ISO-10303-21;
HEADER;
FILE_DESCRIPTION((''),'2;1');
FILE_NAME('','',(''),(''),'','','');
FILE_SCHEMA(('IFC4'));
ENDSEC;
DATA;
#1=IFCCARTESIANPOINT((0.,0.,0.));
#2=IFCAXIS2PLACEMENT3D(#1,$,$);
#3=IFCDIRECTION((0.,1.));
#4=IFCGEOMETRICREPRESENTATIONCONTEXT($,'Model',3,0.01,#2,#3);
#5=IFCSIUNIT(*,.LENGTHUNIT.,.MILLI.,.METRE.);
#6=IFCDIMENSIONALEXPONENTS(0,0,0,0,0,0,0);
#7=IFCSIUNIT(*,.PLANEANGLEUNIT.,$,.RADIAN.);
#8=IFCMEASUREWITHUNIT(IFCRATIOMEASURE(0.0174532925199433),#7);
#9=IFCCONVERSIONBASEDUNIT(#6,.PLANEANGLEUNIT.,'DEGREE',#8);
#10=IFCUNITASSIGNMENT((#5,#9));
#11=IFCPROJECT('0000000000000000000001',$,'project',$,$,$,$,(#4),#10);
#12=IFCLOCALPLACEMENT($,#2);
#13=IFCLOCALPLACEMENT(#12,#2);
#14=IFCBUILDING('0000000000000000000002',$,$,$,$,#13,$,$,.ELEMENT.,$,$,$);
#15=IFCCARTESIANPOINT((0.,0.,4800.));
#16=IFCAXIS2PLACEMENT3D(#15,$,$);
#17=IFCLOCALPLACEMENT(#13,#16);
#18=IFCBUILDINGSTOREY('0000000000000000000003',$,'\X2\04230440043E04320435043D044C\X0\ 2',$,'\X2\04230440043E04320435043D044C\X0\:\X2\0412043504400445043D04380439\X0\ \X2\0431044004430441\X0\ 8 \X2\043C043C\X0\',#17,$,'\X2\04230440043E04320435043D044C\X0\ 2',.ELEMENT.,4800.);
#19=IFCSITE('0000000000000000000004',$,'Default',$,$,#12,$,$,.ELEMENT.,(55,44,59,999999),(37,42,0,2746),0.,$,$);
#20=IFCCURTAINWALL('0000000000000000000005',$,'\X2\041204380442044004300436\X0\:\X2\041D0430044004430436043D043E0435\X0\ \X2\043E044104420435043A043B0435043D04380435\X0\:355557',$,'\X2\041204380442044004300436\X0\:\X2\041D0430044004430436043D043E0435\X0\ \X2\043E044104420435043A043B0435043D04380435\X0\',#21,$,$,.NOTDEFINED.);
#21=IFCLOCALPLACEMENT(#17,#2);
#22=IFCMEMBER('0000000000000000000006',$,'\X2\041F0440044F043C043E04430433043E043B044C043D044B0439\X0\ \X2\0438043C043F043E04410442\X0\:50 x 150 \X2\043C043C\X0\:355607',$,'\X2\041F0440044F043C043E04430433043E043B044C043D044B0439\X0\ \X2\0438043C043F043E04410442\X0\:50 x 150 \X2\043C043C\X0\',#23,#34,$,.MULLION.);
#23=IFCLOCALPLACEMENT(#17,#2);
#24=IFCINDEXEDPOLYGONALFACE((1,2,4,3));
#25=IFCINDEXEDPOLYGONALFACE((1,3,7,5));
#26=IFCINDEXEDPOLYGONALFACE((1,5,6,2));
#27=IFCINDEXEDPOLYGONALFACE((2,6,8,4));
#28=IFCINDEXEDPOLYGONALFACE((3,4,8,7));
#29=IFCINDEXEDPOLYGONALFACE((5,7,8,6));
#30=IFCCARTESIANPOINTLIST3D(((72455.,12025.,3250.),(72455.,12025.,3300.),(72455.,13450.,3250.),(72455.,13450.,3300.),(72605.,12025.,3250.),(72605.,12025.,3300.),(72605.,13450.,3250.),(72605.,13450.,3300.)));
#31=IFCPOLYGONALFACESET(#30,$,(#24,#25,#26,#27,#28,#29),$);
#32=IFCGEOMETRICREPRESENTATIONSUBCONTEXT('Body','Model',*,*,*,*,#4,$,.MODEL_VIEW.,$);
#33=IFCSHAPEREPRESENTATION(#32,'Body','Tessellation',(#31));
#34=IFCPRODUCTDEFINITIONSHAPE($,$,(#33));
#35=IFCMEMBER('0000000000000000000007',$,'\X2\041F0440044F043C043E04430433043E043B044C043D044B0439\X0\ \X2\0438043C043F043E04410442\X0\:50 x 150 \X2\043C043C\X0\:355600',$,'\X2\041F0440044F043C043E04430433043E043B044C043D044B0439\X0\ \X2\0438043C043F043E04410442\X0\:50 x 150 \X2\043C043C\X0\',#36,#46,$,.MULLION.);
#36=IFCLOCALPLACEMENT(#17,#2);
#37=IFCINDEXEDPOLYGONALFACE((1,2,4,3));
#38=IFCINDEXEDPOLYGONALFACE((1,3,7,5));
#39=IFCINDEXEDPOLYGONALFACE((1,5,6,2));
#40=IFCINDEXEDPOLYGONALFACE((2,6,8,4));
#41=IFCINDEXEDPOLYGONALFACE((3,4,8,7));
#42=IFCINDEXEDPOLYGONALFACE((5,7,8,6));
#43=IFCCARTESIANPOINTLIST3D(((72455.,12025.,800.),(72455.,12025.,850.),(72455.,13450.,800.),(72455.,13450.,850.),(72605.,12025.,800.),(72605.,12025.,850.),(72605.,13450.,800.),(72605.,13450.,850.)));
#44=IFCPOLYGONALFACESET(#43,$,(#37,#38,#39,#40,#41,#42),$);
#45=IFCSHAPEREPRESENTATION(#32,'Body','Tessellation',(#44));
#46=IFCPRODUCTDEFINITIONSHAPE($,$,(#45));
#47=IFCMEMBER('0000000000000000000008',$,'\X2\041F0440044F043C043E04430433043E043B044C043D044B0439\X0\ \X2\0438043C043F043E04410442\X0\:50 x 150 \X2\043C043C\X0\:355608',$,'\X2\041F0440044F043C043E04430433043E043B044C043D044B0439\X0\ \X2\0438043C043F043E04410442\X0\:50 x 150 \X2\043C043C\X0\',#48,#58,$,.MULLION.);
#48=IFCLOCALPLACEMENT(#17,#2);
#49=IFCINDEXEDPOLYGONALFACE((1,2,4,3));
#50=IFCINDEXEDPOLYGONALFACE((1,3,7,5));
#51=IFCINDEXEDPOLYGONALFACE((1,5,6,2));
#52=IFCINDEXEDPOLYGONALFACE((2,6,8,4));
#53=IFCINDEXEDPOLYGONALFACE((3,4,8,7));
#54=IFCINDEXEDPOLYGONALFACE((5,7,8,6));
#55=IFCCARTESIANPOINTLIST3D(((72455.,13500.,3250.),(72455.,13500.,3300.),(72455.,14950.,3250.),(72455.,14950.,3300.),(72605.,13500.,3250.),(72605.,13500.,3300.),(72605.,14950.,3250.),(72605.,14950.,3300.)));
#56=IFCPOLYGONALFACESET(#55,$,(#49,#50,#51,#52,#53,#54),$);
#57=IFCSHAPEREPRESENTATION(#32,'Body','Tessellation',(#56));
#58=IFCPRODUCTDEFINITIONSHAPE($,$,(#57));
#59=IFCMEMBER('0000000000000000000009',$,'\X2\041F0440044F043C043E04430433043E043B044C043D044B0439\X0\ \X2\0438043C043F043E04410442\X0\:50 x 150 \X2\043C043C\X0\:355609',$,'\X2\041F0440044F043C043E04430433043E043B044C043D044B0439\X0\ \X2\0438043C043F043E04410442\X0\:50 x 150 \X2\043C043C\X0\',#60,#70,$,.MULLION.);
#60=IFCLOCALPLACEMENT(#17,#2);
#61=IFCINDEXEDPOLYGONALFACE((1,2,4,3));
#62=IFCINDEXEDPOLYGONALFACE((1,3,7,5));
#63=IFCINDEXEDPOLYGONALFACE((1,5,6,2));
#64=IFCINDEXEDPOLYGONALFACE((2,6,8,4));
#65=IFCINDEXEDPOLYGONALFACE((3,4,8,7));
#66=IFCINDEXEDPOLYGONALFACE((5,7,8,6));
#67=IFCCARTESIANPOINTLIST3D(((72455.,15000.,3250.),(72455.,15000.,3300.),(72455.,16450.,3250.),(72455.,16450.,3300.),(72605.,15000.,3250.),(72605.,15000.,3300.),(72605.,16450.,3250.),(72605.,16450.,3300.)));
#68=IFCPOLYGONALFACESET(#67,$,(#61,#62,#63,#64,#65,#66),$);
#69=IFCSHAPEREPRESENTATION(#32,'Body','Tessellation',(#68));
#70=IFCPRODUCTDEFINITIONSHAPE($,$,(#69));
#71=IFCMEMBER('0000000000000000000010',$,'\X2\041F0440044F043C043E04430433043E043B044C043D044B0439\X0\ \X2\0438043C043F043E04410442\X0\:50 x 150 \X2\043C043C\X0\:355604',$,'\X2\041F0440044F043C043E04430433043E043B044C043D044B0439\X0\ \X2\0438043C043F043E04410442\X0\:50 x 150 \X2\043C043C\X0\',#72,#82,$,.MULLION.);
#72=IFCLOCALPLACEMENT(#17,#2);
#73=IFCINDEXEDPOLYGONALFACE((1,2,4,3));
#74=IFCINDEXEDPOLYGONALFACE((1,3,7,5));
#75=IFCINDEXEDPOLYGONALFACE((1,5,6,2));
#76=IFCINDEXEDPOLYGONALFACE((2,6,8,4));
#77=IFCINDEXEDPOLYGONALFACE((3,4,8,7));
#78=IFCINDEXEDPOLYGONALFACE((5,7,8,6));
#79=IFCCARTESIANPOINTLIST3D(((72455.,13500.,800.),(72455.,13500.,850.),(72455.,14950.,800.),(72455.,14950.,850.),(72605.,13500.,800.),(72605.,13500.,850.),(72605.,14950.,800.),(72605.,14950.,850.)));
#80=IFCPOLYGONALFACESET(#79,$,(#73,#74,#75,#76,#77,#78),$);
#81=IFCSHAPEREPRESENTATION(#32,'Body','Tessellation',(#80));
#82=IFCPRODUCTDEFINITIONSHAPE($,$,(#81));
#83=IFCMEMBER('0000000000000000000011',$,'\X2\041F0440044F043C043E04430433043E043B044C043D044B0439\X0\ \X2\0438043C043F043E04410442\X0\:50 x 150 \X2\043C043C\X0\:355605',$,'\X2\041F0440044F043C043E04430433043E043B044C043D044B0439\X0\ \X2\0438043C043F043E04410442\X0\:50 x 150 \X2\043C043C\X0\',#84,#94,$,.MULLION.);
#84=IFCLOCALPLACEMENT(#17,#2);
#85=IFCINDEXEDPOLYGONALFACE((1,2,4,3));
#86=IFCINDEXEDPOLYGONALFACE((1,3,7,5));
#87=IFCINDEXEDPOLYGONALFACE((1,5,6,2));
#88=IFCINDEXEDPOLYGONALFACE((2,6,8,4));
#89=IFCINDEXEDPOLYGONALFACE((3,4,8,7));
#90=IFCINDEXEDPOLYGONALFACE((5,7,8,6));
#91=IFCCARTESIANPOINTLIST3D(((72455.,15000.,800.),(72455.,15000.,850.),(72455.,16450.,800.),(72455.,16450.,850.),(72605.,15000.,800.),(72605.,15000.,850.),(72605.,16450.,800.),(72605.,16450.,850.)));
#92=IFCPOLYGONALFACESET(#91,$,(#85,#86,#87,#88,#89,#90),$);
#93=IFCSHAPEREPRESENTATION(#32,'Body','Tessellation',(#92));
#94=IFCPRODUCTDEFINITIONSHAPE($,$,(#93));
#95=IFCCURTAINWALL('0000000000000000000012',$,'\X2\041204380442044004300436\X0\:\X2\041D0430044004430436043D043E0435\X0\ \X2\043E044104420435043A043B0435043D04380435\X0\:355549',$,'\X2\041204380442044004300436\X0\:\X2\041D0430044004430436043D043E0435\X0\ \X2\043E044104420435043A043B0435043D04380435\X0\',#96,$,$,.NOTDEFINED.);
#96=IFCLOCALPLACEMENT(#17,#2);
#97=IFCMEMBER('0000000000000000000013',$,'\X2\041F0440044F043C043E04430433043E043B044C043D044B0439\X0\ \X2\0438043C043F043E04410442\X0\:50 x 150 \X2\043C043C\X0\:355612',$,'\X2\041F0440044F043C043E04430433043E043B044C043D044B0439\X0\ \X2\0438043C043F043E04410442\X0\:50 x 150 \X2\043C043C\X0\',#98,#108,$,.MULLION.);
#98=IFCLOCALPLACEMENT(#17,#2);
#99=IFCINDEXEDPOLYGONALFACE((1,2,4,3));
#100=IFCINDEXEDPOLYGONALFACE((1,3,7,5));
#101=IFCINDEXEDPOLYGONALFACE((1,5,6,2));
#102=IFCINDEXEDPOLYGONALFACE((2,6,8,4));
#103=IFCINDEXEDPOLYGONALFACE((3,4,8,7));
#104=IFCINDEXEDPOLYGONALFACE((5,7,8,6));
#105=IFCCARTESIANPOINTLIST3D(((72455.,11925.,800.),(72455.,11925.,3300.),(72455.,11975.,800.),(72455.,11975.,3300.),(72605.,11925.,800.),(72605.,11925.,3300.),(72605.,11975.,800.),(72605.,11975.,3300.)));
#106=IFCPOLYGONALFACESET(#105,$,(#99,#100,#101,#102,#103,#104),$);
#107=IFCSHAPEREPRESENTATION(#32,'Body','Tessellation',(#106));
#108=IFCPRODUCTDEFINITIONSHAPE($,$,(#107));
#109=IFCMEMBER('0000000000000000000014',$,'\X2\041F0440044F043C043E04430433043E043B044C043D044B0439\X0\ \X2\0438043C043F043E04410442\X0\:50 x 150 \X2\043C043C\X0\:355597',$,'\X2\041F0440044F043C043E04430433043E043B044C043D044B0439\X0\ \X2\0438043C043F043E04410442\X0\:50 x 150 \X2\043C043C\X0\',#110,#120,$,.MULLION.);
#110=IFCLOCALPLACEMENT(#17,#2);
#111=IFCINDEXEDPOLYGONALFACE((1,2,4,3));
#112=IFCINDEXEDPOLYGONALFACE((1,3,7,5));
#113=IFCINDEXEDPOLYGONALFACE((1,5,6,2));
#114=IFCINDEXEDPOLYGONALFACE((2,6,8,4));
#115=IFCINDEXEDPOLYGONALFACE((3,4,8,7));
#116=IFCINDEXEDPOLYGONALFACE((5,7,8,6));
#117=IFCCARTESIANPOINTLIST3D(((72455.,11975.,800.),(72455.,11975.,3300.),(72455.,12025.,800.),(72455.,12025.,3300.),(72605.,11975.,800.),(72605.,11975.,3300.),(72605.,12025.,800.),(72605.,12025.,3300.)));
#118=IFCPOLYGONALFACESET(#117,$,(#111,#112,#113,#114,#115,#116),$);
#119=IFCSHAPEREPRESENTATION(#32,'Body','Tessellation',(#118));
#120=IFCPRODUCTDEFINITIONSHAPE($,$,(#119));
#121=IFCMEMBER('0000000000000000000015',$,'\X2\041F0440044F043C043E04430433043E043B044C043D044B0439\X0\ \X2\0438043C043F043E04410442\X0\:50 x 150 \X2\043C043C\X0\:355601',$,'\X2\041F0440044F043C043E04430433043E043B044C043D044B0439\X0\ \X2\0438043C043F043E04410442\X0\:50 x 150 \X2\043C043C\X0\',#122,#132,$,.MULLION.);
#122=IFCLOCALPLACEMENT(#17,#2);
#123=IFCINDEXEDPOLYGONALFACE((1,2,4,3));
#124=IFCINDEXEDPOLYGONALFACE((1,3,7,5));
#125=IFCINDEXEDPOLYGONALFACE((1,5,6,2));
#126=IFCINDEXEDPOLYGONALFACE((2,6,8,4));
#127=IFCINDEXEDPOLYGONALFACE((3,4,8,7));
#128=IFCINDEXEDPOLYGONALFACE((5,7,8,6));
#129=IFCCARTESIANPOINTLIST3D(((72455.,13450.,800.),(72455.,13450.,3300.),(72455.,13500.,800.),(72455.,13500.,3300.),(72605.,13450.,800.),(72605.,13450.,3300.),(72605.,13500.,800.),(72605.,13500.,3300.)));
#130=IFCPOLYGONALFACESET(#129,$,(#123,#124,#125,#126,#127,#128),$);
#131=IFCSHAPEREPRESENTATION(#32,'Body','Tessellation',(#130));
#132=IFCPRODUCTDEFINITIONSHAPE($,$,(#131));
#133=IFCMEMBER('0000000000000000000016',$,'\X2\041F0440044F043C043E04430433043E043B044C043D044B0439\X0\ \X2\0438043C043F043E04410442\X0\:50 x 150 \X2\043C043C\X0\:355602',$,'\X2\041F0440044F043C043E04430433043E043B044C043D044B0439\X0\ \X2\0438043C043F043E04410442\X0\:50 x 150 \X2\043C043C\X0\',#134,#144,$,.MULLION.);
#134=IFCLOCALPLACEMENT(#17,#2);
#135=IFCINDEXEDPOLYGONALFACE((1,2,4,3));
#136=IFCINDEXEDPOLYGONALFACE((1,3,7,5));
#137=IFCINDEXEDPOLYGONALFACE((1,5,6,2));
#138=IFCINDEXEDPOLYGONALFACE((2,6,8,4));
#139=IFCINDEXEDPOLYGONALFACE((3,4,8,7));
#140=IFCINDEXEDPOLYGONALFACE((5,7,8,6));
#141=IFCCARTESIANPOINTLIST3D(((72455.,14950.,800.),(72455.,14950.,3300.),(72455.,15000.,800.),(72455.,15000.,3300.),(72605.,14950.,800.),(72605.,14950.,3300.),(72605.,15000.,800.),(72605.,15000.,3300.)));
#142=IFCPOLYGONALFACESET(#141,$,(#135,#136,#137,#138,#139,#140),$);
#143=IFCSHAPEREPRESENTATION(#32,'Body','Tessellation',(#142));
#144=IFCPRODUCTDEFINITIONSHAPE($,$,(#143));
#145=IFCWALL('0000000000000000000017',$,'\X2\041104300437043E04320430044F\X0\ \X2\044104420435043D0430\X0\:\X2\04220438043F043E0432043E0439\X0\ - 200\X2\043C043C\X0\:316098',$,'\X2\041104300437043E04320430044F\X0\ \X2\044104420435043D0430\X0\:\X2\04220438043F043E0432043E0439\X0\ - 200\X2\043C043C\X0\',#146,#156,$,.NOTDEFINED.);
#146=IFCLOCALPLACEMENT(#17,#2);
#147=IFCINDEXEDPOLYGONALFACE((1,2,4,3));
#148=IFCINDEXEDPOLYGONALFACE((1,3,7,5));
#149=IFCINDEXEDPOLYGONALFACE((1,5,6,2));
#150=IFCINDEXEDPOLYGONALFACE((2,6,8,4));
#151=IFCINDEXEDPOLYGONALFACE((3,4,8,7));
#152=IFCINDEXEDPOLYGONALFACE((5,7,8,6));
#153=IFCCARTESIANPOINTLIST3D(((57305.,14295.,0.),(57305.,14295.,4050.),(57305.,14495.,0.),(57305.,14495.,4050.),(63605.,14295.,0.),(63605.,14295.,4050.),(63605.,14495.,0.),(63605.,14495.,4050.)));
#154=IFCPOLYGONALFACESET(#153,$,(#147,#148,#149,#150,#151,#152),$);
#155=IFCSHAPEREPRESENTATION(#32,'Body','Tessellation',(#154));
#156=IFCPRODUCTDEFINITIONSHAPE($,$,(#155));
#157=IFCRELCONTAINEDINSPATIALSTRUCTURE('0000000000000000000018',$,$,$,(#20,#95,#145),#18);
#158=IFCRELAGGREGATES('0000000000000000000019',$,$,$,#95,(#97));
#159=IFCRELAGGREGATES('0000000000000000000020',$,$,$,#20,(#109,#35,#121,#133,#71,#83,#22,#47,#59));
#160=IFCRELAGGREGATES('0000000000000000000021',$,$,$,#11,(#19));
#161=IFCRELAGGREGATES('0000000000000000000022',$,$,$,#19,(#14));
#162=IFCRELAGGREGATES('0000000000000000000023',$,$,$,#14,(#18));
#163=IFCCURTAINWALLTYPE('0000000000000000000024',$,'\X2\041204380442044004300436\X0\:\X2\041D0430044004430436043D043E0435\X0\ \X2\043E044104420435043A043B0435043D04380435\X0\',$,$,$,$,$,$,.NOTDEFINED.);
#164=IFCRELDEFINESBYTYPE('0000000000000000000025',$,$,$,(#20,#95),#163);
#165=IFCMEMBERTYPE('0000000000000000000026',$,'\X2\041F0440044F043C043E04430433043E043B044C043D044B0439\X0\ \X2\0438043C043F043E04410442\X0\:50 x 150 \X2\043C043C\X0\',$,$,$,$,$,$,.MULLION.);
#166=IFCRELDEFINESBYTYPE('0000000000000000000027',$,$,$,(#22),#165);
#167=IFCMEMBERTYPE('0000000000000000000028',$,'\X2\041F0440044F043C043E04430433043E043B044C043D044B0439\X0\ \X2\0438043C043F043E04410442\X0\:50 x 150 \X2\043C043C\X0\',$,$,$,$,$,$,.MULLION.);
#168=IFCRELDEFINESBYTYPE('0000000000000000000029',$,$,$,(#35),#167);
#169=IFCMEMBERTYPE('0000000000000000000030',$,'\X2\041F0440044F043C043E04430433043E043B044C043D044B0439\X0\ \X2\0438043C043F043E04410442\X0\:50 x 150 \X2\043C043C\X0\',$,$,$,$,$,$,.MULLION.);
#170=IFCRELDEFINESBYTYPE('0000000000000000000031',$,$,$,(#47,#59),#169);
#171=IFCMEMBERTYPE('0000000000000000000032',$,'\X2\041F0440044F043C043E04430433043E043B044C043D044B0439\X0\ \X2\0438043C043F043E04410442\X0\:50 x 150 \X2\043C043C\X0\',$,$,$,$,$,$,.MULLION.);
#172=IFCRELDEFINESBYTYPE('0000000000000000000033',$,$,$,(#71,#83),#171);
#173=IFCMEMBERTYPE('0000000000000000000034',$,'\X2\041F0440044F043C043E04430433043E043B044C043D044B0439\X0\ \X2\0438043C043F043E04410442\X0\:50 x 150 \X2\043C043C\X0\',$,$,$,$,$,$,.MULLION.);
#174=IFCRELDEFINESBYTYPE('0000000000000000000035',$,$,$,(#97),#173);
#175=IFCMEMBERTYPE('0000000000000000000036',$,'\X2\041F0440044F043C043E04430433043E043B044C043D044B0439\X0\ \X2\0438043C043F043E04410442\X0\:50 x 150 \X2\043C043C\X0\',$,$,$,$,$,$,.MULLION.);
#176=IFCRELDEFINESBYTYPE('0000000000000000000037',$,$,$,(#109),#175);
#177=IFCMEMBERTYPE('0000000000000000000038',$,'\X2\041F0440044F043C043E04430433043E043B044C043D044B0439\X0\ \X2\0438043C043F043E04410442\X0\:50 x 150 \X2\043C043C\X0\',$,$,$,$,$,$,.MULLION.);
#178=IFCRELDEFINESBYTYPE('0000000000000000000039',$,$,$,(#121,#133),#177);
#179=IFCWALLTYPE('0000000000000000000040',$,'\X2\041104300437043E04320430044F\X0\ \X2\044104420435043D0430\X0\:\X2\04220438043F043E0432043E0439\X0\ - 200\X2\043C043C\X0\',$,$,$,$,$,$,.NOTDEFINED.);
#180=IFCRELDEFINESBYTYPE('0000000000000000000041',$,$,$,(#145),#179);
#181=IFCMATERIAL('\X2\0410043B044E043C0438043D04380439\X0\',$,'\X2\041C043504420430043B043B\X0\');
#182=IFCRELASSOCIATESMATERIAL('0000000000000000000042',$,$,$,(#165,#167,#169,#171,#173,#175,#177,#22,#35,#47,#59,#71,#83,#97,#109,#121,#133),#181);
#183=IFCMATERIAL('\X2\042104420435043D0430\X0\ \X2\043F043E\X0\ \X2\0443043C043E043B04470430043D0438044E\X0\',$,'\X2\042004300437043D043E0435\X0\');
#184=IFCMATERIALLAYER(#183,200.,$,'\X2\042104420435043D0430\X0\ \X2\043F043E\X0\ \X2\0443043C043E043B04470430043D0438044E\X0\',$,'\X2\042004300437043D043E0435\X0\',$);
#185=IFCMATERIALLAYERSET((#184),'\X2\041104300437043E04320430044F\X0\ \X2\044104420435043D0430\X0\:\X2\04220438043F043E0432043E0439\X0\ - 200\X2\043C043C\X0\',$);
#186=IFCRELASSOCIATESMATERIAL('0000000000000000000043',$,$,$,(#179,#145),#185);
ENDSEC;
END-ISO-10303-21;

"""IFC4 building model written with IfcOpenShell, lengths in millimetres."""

from ifc_helpers import new_model, entity, si_unit, converted_unit, direction, frame, frame_2d, origin, origin_2d_with_axis, place, context, subcontext, project, spatial, rectangle, extrude, source, transform, mapped, material, layer, layer_set, layer_usage, material_profile, profile_set, profile_usage, type_object, type_shapes, element, aggregate, save


model = new_model("IFC4")

# Units and contexts
model_context = context("Model", 3, precision=0.01, world=origin(), true_north=direction((0.0, 1.0)))
body_context = subcontext(model_context, "Body", "Model", "MODEL_VIEW")
ifc_project = project(units=[si_unit("LENGTHUNIT", "METRE", prefix="MILLI"), converted_unit("PLANEANGLEUNIT", "DEGREE", entity("IfcRatioMeasure", 0.0174532925199433), si_unit("PLANEANGLEUNIT", "RADIAN"), dimensions=[0, 0, 0, 0, 0, 0, 0])], contexts=[model_context])

# Site, building, storey
site_placement = place(None, origin())
site = spatial("IfcSite", under=ifc_project, at=site_placement, Name="Default", CompositionType="ELEMENT", RefLatitude=(55, 44, 59, 999999), RefLongitude=(37, 42, 0, 2746), RefElevation=0.0)
building_placement = place(site_placement, origin())
building = spatial("IfcBuilding", under=site, at=building_placement, CompositionType="ELEMENT")
storey_placement = place(building_placement, frame((0.0, 0.0, 4800.0)))
storey = spatial("IfcBuildingStorey", under=building, at=storey_placement, Name="Уровень 2", ObjectType="Уровень:Верхний брус 8 мм", LongName="Уровень 2", CompositionType="ELEMENT", Elevation=4800.0)

# Curtain wall, members
curtain_wall_type = type_object("IfcCurtainWallType", Name="Витраж:Наружное остекление", PredefinedType="NOTDEFINED")
curtain_wall_1_placement = place(storey_placement, frame((0.0, 0.0, -4800.0)))
curtain_wall_1 = element("IfcCurtainWall", 1, at=curtain_wall_1_placement, inside=storey, type_object=curtain_wall_type, Name="Витраж:Наружное остекление:355557", ObjectType="Витраж:Наружное остекление", PredefinedType="NOTDEFINED")
ifc_material_1 = material(Name="Алюминий", Category="Металл")
ifc_material_profile = material_profile(ifc_material_1, rectangle(XDim=150.0, YDim=50.0, at=origin_2d_with_axis()), Name="50 x 150 мм")
ifc_profile_set = profile_set([ifc_material_profile], Name="50 x 150 мм")
ifc_profile_usage_1 = profile_usage(ifc_profile_set)
member_type_1 = type_object("IfcMemberType", Name="Прямоугольный импост:50 x 150 мм", PredefinedType="MULLION", material=ifc_profile_set)
shared_shape_1 = source(origin(), body_context, "Body", "SweptSolid", [
    extrude(rectangle(XDim=150.0, YDim=50.0, at=origin_2d_with_axis()), frame((-25.0, 0.0, -1425.0), z_axis=(0.0, 0.0, 1.0), x_axis=(0.0, -1.0, 0.0)), (0.0, 0.0, 1.0), 1425.0),
])
type_shapes(member_type_1, [shared_shape_1])
member_1_placement = place(storey_placement, frame((72530.0, 13450.0, 3300.0), z_axis=(0.0, 1.0, 0.0), x_axis=(0.0, 0.0, 1.0)))
member_1 = element("IfcMember", 2, at=member_1_placement, type_object=member_type_1, material=ifc_profile_usage_1, Name="Прямоугольный импост:50 x 150 мм:355607", ObjectType="Прямоугольный импост:50 x 150 мм", PredefinedType="MULLION", context=body_context, shape_type="MappedRepresentation", body=[
    mapped(shared_shape_1, transform((0.0, 0.0, 0.0), scale=1.0)),
])
ifc_profile_usage_2 = profile_usage(ifc_profile_set)
member_type_2 = type_object("IfcMemberType", Name="Прямоугольный импост:50 x 150 мм", PredefinedType="MULLION", material=ifc_profile_set)
shared_shape_2 = source(origin(), body_context, "Body", "SweptSolid", [
    extrude(rectangle(XDim=150.0, YDim=50.0, at=origin_2d_with_axis()), frame((-25.0, 0.0, -1425.0), z_axis=(0.0, 0.0, 1.0), x_axis=(0.0, -1.0, 0.0)), (0.0, 0.0, 1.0), 1425.0),
])
type_shapes(member_type_2, [shared_shape_2])
member_2_placement = place(storey_placement, frame((72530.0, 12025.0, 800.0), z_axis=(0.0, -1.0, 0.0), x_axis=(0.0, 0.0, -1.0)))
member_2 = element("IfcMember", 3, at=member_2_placement, type_object=member_type_2, material=ifc_profile_usage_2, Name="Прямоугольный импост:50 x 150 мм:355600", ObjectType="Прямоугольный импост:50 x 150 мм", PredefinedType="MULLION", context=body_context, shape_type="MappedRepresentation", body=[
    mapped(shared_shape_2, transform((0.0, 0.0, 0.0), scale=1.0)),
])
ifc_profile_usage_3 = profile_usage(ifc_profile_set)
member_type_3 = type_object("IfcMemberType", Name="Прямоугольный импост:50 x 150 мм", PredefinedType="MULLION", material=ifc_profile_set)
shared_shape_3 = source(origin(), body_context, "Body", "SweptSolid", [
    extrude(rectangle(XDim=150.0, YDim=50.0, at=origin_2d_with_axis()), frame((-25.0, 0.0, -1450.0), z_axis=(0.0, 0.0, 1.0), x_axis=(0.0, -1.0, 0.0)), (0.0, 0.0, 1.0), 1450.0),
])
type_shapes(member_type_3, [shared_shape_3])
member_3_placement = place(storey_placement, frame((72530.0, 14950.0, 3300.0), z_axis=(0.0, 1.0, 0.0), x_axis=(0.0, 0.0, 1.0)))
member_3 = element("IfcMember", 4, at=member_3_placement, type_object=member_type_3, material=ifc_profile_usage_3, Name="Прямоугольный импост:50 x 150 мм:355608", ObjectType="Прямоугольный импост:50 x 150 мм", PredefinedType="MULLION", context=body_context, shape_type="MappedRepresentation", body=[
    mapped(shared_shape_3, transform((0.0, 0.0, 0.0), scale=1.0)),
])
ifc_profile_usage_4 = profile_usage(ifc_profile_set)
member_4_placement = place(storey_placement, frame((72530.0, 16450.0, 3300.0), z_axis=(0.0, 1.0, 0.0), x_axis=(0.0, 0.0, 1.0)))
member_4 = element("IfcMember", 5, at=member_4_placement, type_object=member_type_3, material=ifc_profile_usage_4, Name="Прямоугольный импост:50 x 150 мм:355609", ObjectType="Прямоугольный импост:50 x 150 мм", PredefinedType="MULLION", context=body_context, shape_type="MappedRepresentation", body=[
    mapped(shared_shape_3, transform((0.0, 0.0, 0.0), scale=1.0)),
])
ifc_profile_usage_5 = profile_usage(ifc_profile_set)
member_type_4 = type_object("IfcMemberType", Name="Прямоугольный импост:50 x 150 мм", PredefinedType="MULLION", material=ifc_profile_set)
shared_shape_4 = source(origin(), body_context, "Body", "SweptSolid", [
    extrude(rectangle(XDim=150.0, YDim=50.0, at=origin_2d_with_axis()), frame((-25.0, 0.0, -1450.0), z_axis=(0.0, 0.0, 1.0), x_axis=(0.0, -1.0, 0.0)), (0.0, 0.0, 1.0), 1450.0),
])
type_shapes(member_type_4, [shared_shape_4])
member_5_placement = place(storey_placement, frame((72530.0, 13500.0, 800.0), z_axis=(0.0, -1.0, 0.0), x_axis=(0.0, 0.0, -1.0)))
member_5 = element("IfcMember", 6, at=member_5_placement, type_object=member_type_4, material=ifc_profile_usage_5, Name="Прямоугольный импост:50 x 150 мм:355604", ObjectType="Прямоугольный импост:50 x 150 мм", PredefinedType="MULLION", context=body_context, shape_type="MappedRepresentation", body=[
    mapped(shared_shape_4, transform((0.0, 0.0, 0.0), scale=1.0)),
])
ifc_profile_usage_6 = profile_usage(ifc_profile_set)
member_6_placement = place(storey_placement, frame((72530.0, 15000.0, 800.0), z_axis=(0.0, -1.0, 0.0), x_axis=(0.0, 0.0, -1.0)))
member_6 = element("IfcMember", 7, at=member_6_placement, type_object=member_type_4, material=ifc_profile_usage_6, Name="Прямоугольный импост:50 x 150 мм:355605", ObjectType="Прямоугольный импост:50 x 150 мм", PredefinedType="MULLION", context=body_context, shape_type="MappedRepresentation", body=[
    mapped(shared_shape_4, transform((0.0, 0.0, 0.0), scale=1.0)),
])

# Curtain wall, member
curtain_wall_2_placement = place(storey_placement, frame((0.0, 0.0, -4800.0)))
curtain_wall_2 = element("IfcCurtainWall", 8, at=curtain_wall_2_placement, inside=storey, type_object=curtain_wall_type, Name="Витраж:Наружное остекление:355549", ObjectType="Витраж:Наружное остекление", PredefinedType="NOTDEFINED")
ifc_profile_usage_7 = profile_usage(ifc_profile_set)
member_type_5 = type_object("IfcMemberType", Name="Прямоугольный импост:50 x 150 мм", PredefinedType="MULLION", material=ifc_profile_set)
shared_shape_5 = source(origin(), body_context, "Body", "SweptSolid", [
    extrude(rectangle(XDim=150.0, YDim=50.0, at=origin_2d_with_axis()), frame((-25.0, 0.0, -2500.0), z_axis=(0.0, 0.0, 1.0), x_axis=(0.0, -1.0, 0.0)), (0.0, 0.0, 1.0), 2500.0),
])
type_shapes(member_type_5, [shared_shape_5])
member_7_placement = place(storey_placement, frame((72530.0, 11975.0, 800.0), z_axis=(0.0, 0.0, -1.0), x_axis=(0.0, 1.0, 0.0)))
member_7 = element("IfcMember", 9, at=member_7_placement, type_object=member_type_5, material=ifc_profile_usage_7, Name="Прямоугольный импост:50 x 150 мм:355612", ObjectType="Прямоугольный импост:50 x 150 мм", PredefinedType="MULLION", context=body_context, shape_type="MappedRepresentation", body=[
    mapped(shared_shape_5, transform((0.0, 0.0, 0.0), scale=1.0)),
])
aggregate(curtain_wall_2, [member_7])

# Members
ifc_profile_usage_8 = profile_usage(ifc_profile_set)
member_type_6 = type_object("IfcMemberType", Name="Прямоугольный импост:50 x 150 мм", PredefinedType="MULLION", material=ifc_profile_set)
shared_shape_6 = source(origin(), body_context, "Body", "SweptSolid", [
    extrude(rectangle(XDim=150.0, YDim=50.0, at=origin_2d_with_axis()), frame((-25.0, 0.0, -2500.0), z_axis=(0.0, 0.0, 1.0), x_axis=(0.0, -1.0, 0.0)), (0.0, 0.0, 1.0), 2500.0),
])
type_shapes(member_type_6, [shared_shape_6])
member_8_placement = place(storey_placement, frame((72530.0, 11975.0, 3300.0), z_axis=(0.0, 0.0, 1.0), x_axis=(0.0, -1.0, 0.0)))
member_8 = element("IfcMember", 10, at=member_8_placement, type_object=member_type_6, material=ifc_profile_usage_8, Name="Прямоугольный импост:50 x 150 мм:355597", ObjectType="Прямоугольный импост:50 x 150 мм", PredefinedType="MULLION", context=body_context, shape_type="MappedRepresentation", body=[
    mapped(shared_shape_6, transform((0.0, 0.0, 0.0), scale=1.0)),
])
ifc_profile_usage_9 = profile_usage(ifc_profile_set)
member_type_7 = type_object("IfcMemberType", Name="Прямоугольный импост:50 x 150 мм", PredefinedType="MULLION", material=ifc_profile_set)
shared_shape_7 = source(origin(), body_context, "Body", "SweptSolid", [
    extrude(rectangle(XDim=150.0, YDim=50.0, at=origin_2d_with_axis()), frame((0.0, 0.0, -2500.0), z_axis=(0.0, 0.0, 1.0), x_axis=(0.0, -1.0, 0.0)), (0.0, 0.0, 1.0), 2500.0),
])
type_shapes(member_type_7, [shared_shape_7])
member_9_placement = place(storey_placement, frame((72530.0, 13475.0, 800.0), z_axis=(0.0, 0.0, -1.0), x_axis=(0.0, 1.0, 0.0)))
member_9 = element("IfcMember", 11, at=member_9_placement, type_object=member_type_7, material=ifc_profile_usage_9, Name="Прямоугольный импост:50 x 150 мм:355601", ObjectType="Прямоугольный импост:50 x 150 мм", PredefinedType="MULLION", context=body_context, shape_type="MappedRepresentation", body=[
    mapped(shared_shape_7, transform((0.0, 0.0, 0.0), scale=1.0)),
])
ifc_profile_usage_10 = profile_usage(ifc_profile_set)
member_10_placement = place(storey_placement, frame((72530.0, 14975.0, 800.0), z_axis=(0.0, 0.0, -1.0), x_axis=(0.0, 1.0, 0.0)))
member_10 = element("IfcMember", 12, at=member_10_placement, type_object=member_type_7, material=ifc_profile_usage_10, Name="Прямоугольный импост:50 x 150 мм:355602", ObjectType="Прямоугольный импост:50 x 150 мм", PredefinedType="MULLION", context=body_context, shape_type="MappedRepresentation", body=[
    mapped(shared_shape_7, transform((0.0, 0.0, 0.0), scale=1.0)),
])

aggregate(curtain_wall_1, [member_8, member_2, member_9, member_10, member_5, member_6, member_1, member_3, member_4])

# Shared definitions
ifc_material_2 = material(Name="Стена по умолчанию", Category="Разное")
ifc_layer = layer(ifc_material_2, 200.0, Name="Стена по умолчанию", Category="Разное")
ifc_layer_set = layer_set([ifc_layer], Name="Базовая стена:Типовой - 200мм")
wall_type = type_object("IfcWallType", Name="Базовая стена:Типовой - 200мм", PredefinedType="NOTDEFINED", material=ifc_layer_set)

# Wall
ifc_layer_usage_1 = layer_usage(ifc_layer_set, "AXIS2", "NEGATIVE", 100.0)
wall_1_placement = place(storey_placement, frame((63605.0, 14395.0, 0.0), z_axis=(0.0, 0.0, 1.0), x_axis=(-1.0, 0.0, 0.0)))
element("IfcWall", 13, at=wall_1_placement, inside=storey, type_object=wall_type, material=ifc_layer_usage_1, Name="Базовая стена:Типовой - 200мм:316098", ObjectType="Базовая стена:Типовой - 200мм", PredefinedType="NOTDEFINED", context=body_context, shape_type="SweptSolid", body=[
    extrude(rectangle(XDim=6300.0, YDim=200.0, at=frame_2d((3150.0, 0.0), x_axis=(-1.0, 0.0))), origin(), (0.0, 0.0, 1.0), 4050.0),
])

save(model, "model.ifc")
